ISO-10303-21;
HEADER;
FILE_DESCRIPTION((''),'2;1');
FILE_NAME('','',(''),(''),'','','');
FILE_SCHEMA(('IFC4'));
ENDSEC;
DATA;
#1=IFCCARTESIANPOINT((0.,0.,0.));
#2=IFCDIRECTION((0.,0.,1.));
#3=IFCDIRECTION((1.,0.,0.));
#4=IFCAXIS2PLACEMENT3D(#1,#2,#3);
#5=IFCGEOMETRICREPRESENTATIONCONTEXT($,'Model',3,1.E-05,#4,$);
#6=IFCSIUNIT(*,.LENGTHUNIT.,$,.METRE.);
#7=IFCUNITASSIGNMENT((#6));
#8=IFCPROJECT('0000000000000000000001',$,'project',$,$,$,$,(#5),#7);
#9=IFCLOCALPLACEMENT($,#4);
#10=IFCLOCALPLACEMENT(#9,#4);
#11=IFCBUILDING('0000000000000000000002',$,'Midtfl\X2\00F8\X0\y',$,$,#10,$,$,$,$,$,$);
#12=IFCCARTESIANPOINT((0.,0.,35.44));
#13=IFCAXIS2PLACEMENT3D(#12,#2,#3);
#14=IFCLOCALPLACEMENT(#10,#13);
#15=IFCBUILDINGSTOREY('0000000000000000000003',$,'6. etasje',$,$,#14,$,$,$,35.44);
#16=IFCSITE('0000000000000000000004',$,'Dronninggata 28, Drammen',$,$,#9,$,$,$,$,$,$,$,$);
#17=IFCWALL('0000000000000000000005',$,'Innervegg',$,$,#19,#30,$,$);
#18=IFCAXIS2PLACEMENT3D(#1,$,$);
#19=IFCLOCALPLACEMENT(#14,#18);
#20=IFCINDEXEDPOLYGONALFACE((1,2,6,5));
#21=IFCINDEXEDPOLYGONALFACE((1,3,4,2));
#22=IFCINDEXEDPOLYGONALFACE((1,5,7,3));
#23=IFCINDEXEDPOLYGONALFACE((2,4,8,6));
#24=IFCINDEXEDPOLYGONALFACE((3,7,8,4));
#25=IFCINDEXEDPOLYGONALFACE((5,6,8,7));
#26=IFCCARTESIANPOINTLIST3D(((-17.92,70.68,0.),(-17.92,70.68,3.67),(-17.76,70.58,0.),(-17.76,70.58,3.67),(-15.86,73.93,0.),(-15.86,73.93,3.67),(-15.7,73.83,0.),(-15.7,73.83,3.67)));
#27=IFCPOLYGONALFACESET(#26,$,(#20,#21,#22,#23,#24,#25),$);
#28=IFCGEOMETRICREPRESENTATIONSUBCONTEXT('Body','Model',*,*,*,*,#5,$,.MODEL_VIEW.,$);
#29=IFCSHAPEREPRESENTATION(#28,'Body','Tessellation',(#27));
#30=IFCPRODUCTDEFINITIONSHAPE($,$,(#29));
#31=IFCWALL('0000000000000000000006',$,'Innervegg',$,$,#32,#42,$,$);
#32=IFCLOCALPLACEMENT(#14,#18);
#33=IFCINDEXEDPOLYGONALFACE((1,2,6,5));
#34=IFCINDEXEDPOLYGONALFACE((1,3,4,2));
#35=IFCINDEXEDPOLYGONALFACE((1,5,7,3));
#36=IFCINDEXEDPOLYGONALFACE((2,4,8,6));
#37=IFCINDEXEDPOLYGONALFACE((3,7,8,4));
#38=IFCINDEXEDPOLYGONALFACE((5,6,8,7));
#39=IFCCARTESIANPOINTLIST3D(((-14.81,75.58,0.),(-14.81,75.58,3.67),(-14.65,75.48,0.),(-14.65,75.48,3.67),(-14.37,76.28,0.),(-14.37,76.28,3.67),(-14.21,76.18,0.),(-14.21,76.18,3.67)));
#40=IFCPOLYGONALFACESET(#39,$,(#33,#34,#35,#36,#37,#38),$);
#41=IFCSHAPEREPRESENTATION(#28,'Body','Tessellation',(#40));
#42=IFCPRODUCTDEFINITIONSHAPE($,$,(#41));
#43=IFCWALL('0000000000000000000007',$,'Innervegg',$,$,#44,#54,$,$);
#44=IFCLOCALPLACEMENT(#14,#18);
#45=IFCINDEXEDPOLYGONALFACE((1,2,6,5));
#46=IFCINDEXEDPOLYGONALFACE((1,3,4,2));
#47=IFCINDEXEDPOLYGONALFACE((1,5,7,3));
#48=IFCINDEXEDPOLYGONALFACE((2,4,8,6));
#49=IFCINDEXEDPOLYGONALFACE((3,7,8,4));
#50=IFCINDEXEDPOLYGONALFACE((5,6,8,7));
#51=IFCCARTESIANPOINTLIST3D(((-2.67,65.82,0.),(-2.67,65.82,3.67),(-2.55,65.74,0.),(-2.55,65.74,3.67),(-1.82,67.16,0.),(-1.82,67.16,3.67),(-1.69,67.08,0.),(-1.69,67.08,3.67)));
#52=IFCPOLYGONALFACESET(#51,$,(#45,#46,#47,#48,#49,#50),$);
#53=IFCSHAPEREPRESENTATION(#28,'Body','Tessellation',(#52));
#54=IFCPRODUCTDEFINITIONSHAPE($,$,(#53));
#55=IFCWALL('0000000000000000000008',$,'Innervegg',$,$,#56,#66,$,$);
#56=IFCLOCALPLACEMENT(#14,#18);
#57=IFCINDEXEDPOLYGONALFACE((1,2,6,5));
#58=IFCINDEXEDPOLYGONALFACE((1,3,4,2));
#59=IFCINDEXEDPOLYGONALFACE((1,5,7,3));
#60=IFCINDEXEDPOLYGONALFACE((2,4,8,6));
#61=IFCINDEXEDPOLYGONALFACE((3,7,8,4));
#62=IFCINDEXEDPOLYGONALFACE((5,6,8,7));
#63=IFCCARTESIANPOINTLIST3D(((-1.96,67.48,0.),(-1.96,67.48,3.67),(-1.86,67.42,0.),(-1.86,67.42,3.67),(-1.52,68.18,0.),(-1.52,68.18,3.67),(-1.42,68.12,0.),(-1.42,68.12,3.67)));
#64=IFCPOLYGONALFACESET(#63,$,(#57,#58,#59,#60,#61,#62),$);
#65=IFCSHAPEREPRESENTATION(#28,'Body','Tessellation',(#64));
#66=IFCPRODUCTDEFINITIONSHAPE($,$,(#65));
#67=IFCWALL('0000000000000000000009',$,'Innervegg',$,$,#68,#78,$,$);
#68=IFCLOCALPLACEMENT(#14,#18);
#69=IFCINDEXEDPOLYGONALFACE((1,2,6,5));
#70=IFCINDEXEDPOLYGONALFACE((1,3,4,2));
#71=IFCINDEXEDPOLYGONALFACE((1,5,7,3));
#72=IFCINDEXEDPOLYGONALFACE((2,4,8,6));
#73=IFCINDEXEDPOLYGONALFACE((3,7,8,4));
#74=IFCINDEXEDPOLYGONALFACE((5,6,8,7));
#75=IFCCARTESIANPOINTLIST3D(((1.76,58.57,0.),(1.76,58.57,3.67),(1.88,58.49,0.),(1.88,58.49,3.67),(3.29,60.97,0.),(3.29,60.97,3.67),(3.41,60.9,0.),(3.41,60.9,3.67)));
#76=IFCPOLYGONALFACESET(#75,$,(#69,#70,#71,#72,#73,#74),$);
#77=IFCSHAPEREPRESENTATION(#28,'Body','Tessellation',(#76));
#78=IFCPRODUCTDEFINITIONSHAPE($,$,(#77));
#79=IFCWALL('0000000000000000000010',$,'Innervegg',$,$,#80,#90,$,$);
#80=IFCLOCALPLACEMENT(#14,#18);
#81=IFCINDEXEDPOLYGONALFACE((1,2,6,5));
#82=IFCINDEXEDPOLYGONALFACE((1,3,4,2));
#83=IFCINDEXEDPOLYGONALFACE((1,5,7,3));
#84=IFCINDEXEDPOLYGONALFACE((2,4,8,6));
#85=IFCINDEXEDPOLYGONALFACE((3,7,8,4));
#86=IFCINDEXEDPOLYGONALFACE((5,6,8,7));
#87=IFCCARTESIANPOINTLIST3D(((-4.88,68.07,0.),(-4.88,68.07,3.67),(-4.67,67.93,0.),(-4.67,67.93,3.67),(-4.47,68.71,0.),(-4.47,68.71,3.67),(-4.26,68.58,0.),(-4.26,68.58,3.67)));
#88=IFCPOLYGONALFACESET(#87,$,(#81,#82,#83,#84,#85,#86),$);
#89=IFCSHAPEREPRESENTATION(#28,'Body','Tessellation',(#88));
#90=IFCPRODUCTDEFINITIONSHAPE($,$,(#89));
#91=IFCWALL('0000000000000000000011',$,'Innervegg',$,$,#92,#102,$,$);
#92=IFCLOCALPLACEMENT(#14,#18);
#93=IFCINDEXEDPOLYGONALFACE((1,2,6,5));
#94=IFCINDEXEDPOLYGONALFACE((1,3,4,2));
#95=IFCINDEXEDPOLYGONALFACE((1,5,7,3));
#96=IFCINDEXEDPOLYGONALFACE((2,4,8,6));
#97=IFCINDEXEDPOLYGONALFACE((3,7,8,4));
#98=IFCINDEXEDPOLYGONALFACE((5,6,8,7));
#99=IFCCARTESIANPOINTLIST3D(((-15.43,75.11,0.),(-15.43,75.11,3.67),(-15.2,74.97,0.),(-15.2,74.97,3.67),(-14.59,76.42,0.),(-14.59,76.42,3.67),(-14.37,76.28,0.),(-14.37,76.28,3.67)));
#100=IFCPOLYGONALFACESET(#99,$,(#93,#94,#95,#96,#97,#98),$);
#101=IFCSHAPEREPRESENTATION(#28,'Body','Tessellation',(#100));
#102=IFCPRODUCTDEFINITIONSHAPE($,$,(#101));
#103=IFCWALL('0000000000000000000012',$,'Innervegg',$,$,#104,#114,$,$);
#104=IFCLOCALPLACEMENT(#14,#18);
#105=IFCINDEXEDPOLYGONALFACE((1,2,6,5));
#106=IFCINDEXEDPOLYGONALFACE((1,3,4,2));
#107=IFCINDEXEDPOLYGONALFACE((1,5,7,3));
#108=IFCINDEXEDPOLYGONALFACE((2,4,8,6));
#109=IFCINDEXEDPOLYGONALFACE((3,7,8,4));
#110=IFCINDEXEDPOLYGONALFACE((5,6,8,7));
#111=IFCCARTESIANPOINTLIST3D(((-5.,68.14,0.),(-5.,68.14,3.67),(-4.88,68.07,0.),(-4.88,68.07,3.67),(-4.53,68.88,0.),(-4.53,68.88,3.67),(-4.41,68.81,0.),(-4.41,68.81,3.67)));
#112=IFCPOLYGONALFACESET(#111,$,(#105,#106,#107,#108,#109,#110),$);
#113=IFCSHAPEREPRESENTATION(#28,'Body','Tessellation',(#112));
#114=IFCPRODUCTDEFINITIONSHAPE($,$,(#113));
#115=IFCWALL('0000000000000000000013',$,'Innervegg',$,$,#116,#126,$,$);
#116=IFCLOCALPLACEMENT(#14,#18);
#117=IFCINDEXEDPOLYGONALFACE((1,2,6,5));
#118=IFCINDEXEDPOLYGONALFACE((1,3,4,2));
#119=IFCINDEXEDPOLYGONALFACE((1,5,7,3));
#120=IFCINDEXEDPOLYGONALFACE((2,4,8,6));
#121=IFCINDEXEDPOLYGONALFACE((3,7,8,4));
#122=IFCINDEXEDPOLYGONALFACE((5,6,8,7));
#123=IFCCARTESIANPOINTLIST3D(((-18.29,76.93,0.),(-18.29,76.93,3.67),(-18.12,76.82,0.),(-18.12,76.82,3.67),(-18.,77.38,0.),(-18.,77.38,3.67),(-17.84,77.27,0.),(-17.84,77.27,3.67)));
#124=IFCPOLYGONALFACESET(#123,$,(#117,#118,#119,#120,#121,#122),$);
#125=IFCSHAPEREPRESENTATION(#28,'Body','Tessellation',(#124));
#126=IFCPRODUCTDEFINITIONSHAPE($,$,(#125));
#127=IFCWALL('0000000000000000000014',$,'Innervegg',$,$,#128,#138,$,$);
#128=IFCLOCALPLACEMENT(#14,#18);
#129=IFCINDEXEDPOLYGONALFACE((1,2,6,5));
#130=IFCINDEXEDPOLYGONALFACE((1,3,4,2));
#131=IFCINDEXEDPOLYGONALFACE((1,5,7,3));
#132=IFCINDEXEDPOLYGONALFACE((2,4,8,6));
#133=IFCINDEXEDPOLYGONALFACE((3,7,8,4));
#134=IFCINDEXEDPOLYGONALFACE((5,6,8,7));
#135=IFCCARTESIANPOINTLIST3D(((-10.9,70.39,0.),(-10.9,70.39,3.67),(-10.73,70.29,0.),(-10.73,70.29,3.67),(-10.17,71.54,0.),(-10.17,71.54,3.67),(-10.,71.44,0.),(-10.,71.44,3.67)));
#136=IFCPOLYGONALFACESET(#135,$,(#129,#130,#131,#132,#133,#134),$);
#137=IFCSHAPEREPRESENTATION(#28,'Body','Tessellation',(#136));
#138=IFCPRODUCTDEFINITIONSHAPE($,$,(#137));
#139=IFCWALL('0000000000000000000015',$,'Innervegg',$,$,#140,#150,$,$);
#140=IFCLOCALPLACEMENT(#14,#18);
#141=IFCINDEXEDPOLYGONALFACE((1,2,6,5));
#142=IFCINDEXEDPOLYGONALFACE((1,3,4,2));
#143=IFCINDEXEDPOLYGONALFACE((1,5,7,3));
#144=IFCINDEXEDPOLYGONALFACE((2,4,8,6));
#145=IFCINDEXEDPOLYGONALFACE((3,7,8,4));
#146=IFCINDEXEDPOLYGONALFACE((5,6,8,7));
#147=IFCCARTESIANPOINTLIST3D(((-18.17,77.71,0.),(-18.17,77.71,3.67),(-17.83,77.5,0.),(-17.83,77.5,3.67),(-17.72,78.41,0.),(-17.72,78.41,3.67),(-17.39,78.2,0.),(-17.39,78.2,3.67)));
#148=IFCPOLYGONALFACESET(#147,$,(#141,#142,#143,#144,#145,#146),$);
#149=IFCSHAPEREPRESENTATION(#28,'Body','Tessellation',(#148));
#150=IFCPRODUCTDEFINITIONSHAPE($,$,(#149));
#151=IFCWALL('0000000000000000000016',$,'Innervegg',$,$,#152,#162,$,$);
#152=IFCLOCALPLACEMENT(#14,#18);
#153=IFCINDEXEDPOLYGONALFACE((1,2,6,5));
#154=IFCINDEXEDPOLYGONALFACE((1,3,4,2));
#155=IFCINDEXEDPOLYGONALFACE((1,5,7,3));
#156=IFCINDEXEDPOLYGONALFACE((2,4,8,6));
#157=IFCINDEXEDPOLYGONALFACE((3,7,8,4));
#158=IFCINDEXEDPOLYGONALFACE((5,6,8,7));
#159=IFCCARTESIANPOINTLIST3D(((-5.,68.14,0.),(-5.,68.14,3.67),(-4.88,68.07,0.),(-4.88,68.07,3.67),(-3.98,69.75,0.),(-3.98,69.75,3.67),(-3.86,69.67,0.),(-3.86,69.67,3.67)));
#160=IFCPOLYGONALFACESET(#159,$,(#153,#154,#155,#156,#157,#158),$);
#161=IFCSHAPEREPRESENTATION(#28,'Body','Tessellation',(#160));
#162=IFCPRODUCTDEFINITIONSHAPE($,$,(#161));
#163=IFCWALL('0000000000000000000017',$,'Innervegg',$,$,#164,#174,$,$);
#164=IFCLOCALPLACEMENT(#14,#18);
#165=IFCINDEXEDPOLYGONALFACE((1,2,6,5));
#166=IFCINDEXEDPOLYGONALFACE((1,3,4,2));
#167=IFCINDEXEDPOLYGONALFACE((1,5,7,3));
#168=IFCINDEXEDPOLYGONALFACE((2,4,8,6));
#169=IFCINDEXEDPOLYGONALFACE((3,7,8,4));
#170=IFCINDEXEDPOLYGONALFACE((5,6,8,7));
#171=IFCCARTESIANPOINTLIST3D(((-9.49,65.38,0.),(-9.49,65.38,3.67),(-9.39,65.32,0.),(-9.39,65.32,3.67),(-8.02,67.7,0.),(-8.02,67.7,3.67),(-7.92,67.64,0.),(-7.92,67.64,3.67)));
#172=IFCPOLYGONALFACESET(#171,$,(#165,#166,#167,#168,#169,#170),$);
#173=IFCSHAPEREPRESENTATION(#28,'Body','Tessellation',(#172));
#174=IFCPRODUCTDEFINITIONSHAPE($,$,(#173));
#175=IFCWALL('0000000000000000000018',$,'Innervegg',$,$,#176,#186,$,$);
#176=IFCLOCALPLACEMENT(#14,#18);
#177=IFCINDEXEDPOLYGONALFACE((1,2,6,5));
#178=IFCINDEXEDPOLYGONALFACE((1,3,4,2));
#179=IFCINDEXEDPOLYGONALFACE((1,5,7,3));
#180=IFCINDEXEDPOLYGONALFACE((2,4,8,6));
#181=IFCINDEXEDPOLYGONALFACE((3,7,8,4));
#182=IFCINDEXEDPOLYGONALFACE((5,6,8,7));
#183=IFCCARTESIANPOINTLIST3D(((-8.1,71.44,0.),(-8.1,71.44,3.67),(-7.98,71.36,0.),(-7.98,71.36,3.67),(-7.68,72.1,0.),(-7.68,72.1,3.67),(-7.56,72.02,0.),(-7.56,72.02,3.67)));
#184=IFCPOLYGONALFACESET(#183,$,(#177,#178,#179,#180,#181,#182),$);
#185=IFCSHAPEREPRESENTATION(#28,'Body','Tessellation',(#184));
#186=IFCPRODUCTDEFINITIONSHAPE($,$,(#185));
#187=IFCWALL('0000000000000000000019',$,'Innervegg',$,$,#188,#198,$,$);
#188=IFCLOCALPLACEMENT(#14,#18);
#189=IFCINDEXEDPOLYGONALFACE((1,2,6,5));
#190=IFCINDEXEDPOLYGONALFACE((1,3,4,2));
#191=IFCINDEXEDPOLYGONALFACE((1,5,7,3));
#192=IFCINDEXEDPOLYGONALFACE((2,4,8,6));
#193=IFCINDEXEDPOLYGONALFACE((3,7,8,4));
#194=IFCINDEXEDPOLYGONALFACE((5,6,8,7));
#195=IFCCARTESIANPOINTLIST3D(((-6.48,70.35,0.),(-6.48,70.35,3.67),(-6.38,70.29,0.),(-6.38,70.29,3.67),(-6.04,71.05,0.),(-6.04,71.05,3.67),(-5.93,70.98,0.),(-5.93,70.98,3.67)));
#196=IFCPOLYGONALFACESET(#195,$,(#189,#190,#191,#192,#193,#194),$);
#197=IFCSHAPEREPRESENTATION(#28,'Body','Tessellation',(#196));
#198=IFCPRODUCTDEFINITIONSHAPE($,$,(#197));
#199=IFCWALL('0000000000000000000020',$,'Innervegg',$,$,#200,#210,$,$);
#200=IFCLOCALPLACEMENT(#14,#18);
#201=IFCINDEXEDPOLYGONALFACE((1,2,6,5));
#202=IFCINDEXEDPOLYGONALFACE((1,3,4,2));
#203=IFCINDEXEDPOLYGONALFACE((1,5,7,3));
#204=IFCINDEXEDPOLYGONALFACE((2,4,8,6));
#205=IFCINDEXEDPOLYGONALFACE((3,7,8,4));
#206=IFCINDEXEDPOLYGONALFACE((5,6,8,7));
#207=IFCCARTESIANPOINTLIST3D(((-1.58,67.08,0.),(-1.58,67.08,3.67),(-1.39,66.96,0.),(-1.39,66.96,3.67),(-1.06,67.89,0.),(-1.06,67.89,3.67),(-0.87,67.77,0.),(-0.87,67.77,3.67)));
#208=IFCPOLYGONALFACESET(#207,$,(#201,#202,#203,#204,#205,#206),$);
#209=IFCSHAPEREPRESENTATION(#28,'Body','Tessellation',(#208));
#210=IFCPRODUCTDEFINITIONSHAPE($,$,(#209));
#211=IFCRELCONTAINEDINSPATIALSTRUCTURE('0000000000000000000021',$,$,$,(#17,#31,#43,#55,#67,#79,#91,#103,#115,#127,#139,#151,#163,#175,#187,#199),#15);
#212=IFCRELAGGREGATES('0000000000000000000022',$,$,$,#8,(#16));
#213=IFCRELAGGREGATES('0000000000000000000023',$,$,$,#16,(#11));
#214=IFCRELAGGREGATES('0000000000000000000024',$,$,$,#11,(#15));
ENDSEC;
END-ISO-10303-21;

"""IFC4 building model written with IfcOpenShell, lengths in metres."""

from ifc_helpers import new_model, si_unit, frame, origin_with_axes, place, context, subcontext, project, spatial, polyline, outline, extrude, element, save


model = new_model("IFC4")

# Units and contexts
model_context = context("Model", 3, precision=1e-05, world=origin_with_axes())
body_context = subcontext(model_context, "Body", "Model", "MODEL_VIEW")
ifc_project = project(units=[si_unit("LENGTHUNIT", "METRE")], contexts=[model_context])

# Site, building, storey
site_placement = place(None, origin_with_axes())
site = spatial("IfcSite", under=ifc_project, at=site_placement, Name="Dronninggata 28, Drammen")
building_placement = place(site_placement, origin_with_axes())
building = spatial("IfcBuilding", under=site, at=building_placement, Name="Midtfløy")
storey_placement = place(building_placement, frame((0.0, 0.0, 35.44), z_axis=(0.0, 0.0, 1.0), x_axis=(1.0, 0.0, 0.0)))
storey = spatial("IfcBuildingStorey", under=building, at=storey_placement, Name="6. etasje", Elevation=35.44)

# Walls
wall_1_placement = place(storey_placement, frame((0.0, 0.0, -35.44), z_axis=(0.0, 0.0, 1.0), x_axis=(1.0, 0.0, 0.0)))
element("IfcWall", 1, at=wall_1_placement, inside=storey, Name="Innervegg", context=body_context, shape_type="SweptSolid", body=[
    extrude(outline(polyline([(-15.86, 73.93), (-15.7, 73.83), (-17.76, 70.58), (-17.92, 70.68), (-15.86, 73.93)])), frame((0.0, 0.0, 35.44)), (0.0, 0.0, 1.0), 3.67),
])
wall_2_placement = place(storey_placement, frame((0.0, 0.0, -35.44), z_axis=(0.0, 0.0, 1.0), x_axis=(1.0, 0.0, 0.0)))
element("IfcWall", 2, at=wall_2_placement, inside=storey, Name="Innervegg", context=body_context, shape_type="SweptSolid", body=[
    extrude(outline(polyline([(-14.37, 76.28), (-14.21, 76.18), (-14.65, 75.48), (-14.81, 75.58), (-14.37, 76.28)])), frame((0.0, 0.0, 35.44)), (0.0, 0.0, 1.0), 3.67),
])
wall_3_placement = place(storey_placement, frame((0.0, 0.0, -35.44), z_axis=(0.0, 0.0, 1.0), x_axis=(1.0, 0.0, 0.0)))
element("IfcWall", 3, at=wall_3_placement, inside=storey, Name="Innervegg", context=body_context, shape_type="SweptSolid", body=[
    extrude(outline(polyline([(-1.82, 67.16), (-1.69, 67.08), (-2.55, 65.74), (-2.67, 65.82), (-1.82, 67.16)])), frame((0.0, 0.0, 35.44)), (0.0, 0.0, 1.0), 3.67),
])
wall_4_placement = place(storey_placement, frame((0.0, 0.0, -35.44), z_axis=(0.0, 0.0, 1.0), x_axis=(1.0, 0.0, 0.0)))
element("IfcWall", 4, at=wall_4_placement, inside=storey, Name="Innervegg", context=body_context, shape_type="SweptSolid", body=[
    extrude(outline(polyline([(-1.52, 68.18), (-1.42, 68.12), (-1.86, 67.42), (-1.96, 67.48), (-1.52, 68.18)])), frame((0.0, 0.0, 35.44)), (0.0, 0.0, 1.0), 3.67),
])
wall_5_placement = place(storey_placement, frame((0.0, 0.0, -35.44), z_axis=(0.0, 0.0, 1.0), x_axis=(1.0, 0.0, 0.0)))
element("IfcWall", 5, at=wall_5_placement, inside=storey, Name="Innervegg", context=body_context, shape_type="SweptSolid", body=[
    extrude(outline(polyline([(3.29, 60.97), (3.41, 60.9), (1.88, 58.49), (1.76, 58.57), (3.29, 60.97)])), frame((0.0, 0.0, 35.44)), (0.0, 0.0, 1.0), 3.67),
])
wall_6_placement = place(storey_placement, frame((0.0, 0.0, -35.44), z_axis=(0.0, 0.0, 1.0), x_axis=(1.0, 0.0, 0.0)))
element("IfcWall", 6, at=wall_6_placement, inside=storey, Name="Innervegg", context=body_context, shape_type="SweptSolid", body=[
    extrude(outline(polyline([(-4.47, 68.71), (-4.26, 68.58), (-4.67, 67.93), (-4.88, 68.07), (-4.47, 68.71)])), frame((0.0, 0.0, 35.44)), (0.0, 0.0, 1.0), 3.67),
])
wall_7_placement = place(storey_placement, frame((0.0, 0.0, -35.44), z_axis=(0.0, 0.0, 1.0), x_axis=(1.0, 0.0, 0.0)))
element("IfcWall", 7, at=wall_7_placement, inside=storey, Name="Innervegg", context=body_context, shape_type="SweptSolid", body=[
    extrude(outline(polyline([(-14.59, 76.42), (-14.37, 76.28), (-15.2, 74.97), (-15.43, 75.11), (-14.59, 76.42)])), frame((0.0, 0.0, 35.44)), (0.0, 0.0, 1.0), 3.67),
])
wall_8_placement = place(storey_placement, frame((0.0, 0.0, -35.44), z_axis=(0.0, 0.0, 1.0), x_axis=(1.0, 0.0, 0.0)))
element("IfcWall", 8, at=wall_8_placement, inside=storey, Name="Innervegg", context=body_context, shape_type="SweptSolid", body=[
    extrude(outline(polyline([(-4.53, 68.88), (-4.41, 68.81), (-4.88, 68.07), (-5.0, 68.14), (-4.53, 68.88)])), frame((0.0, 0.0, 35.44)), (0.0, 0.0, 1.0), 3.67),
])
wall_9_placement = place(storey_placement, frame((0.0, 0.0, -35.44), z_axis=(0.0, 0.0, 1.0), x_axis=(1.0, 0.0, 0.0)))
element("IfcWall", 9, at=wall_9_placement, inside=storey, Name="Innervegg", context=body_context, shape_type="SweptSolid", body=[
    extrude(outline(polyline([(-18.0, 77.38), (-17.84, 77.27), (-18.12, 76.82), (-18.29, 76.93), (-18.0, 77.38)])), frame((0.0, 0.0, 35.44)), (0.0, 0.0, 1.0), 3.67),
])
wall_10_placement = place(storey_placement, frame((0.0, 0.0, -35.44), z_axis=(0.0, 0.0, 1.0), x_axis=(1.0, 0.0, 0.0)))
element("IfcWall", 10, at=wall_10_placement, inside=storey, Name="Innervegg", context=body_context, shape_type="SweptSolid", body=[
    extrude(outline(polyline([(-10.17, 71.54), (-10.0, 71.44), (-10.73, 70.29), (-10.9, 70.39), (-10.17, 71.54)])), frame((0.0, 0.0, 35.44)), (0.0, 0.0, 1.0), 3.67),
])
wall_11_placement = place(storey_placement, frame((0.0, 0.0, -35.44), z_axis=(0.0, 0.0, 1.0), x_axis=(1.0, 0.0, 0.0)))
element("IfcWall", 11, at=wall_11_placement, inside=storey, Name="Innervegg", context=body_context, shape_type="SweptSolid", body=[
    extrude(outline(polyline([(-17.72, 78.41), (-17.39, 78.2), (-17.83, 77.5), (-18.17, 77.71), (-17.72, 78.41)])), frame((0.0, 0.0, 35.44)), (0.0, 0.0, 1.0), 3.67),
])
wall_12_placement = place(storey_placement, frame((0.0, 0.0, -35.44), z_axis=(0.0, 0.0, 1.0), x_axis=(1.0, 0.0, 0.0)))
element("IfcWall", 12, at=wall_12_placement, inside=storey, Name="Innervegg", context=body_context, shape_type="SweptSolid", body=[
    extrude(outline(polyline([(-3.98, 69.75), (-3.86, 69.67), (-4.88, 68.07), (-5.0, 68.14), (-3.98, 69.75)])), frame((0.0, 0.0, 35.44)), (0.0, 0.0, 1.0), 3.67),
])
wall_13_placement = place(storey_placement, frame((0.0, 0.0, -35.44), z_axis=(0.0, 0.0, 1.0), x_axis=(1.0, 0.0, 0.0)))
element("IfcWall", 13, at=wall_13_placement, inside=storey, Name="Innervegg", context=body_context, shape_type="SweptSolid", body=[
    extrude(outline(polyline([(-8.02, 67.7), (-7.92, 67.64), (-9.39, 65.32), (-9.49, 65.38), (-8.02, 67.7)])), frame((0.0, 0.0, 35.44)), (0.0, 0.0, 1.0), 3.67),
])
wall_14_placement = place(storey_placement, frame((0.0, 0.0, -35.44), z_axis=(0.0, 0.0, 1.0), x_axis=(1.0, 0.0, 0.0)))
element("IfcWall", 14, at=wall_14_placement, inside=storey, Name="Innervegg", context=body_context, shape_type="SweptSolid", body=[
    extrude(outline(polyline([(-7.68, 72.1), (-7.56, 72.02), (-7.98, 71.36), (-8.1, 71.44), (-7.68, 72.1)])), frame((0.0, 0.0, 35.44)), (0.0, 0.0, 1.0), 3.67),
])
wall_15_placement = place(storey_placement, frame((0.0, 0.0, -35.44), z_axis=(0.0, 0.0, 1.0), x_axis=(1.0, 0.0, 0.0)))
element("IfcWall", 15, at=wall_15_placement, inside=storey, Name="Innervegg", context=body_context, shape_type="SweptSolid", body=[
    extrude(outline(polyline([(-6.04, 71.05), (-5.93, 70.98), (-6.38, 70.29), (-6.48, 70.35), (-6.04, 71.05)])), frame((0.0, 0.0, 35.44)), (0.0, 0.0, 1.0), 3.67),
])
wall_16_placement = place(storey_placement, frame((0.0, 0.0, -35.44), z_axis=(0.0, 0.0, 1.0), x_axis=(1.0, 0.0, 0.0)))
element("IfcWall", 16, at=wall_16_placement, inside=storey, Name="Innervegg", context=body_context, shape_type="SweptSolid", body=[
    extrude(outline(polyline([(-1.06, 67.89), (-0.87, 67.77), (-1.39, 66.96), (-1.58, 67.08), (-1.06, 67.89)])), frame((0.0, 0.0, 35.44)), (0.0, 0.0, 1.0), 3.67),
])

save(model, "model.ifc")
